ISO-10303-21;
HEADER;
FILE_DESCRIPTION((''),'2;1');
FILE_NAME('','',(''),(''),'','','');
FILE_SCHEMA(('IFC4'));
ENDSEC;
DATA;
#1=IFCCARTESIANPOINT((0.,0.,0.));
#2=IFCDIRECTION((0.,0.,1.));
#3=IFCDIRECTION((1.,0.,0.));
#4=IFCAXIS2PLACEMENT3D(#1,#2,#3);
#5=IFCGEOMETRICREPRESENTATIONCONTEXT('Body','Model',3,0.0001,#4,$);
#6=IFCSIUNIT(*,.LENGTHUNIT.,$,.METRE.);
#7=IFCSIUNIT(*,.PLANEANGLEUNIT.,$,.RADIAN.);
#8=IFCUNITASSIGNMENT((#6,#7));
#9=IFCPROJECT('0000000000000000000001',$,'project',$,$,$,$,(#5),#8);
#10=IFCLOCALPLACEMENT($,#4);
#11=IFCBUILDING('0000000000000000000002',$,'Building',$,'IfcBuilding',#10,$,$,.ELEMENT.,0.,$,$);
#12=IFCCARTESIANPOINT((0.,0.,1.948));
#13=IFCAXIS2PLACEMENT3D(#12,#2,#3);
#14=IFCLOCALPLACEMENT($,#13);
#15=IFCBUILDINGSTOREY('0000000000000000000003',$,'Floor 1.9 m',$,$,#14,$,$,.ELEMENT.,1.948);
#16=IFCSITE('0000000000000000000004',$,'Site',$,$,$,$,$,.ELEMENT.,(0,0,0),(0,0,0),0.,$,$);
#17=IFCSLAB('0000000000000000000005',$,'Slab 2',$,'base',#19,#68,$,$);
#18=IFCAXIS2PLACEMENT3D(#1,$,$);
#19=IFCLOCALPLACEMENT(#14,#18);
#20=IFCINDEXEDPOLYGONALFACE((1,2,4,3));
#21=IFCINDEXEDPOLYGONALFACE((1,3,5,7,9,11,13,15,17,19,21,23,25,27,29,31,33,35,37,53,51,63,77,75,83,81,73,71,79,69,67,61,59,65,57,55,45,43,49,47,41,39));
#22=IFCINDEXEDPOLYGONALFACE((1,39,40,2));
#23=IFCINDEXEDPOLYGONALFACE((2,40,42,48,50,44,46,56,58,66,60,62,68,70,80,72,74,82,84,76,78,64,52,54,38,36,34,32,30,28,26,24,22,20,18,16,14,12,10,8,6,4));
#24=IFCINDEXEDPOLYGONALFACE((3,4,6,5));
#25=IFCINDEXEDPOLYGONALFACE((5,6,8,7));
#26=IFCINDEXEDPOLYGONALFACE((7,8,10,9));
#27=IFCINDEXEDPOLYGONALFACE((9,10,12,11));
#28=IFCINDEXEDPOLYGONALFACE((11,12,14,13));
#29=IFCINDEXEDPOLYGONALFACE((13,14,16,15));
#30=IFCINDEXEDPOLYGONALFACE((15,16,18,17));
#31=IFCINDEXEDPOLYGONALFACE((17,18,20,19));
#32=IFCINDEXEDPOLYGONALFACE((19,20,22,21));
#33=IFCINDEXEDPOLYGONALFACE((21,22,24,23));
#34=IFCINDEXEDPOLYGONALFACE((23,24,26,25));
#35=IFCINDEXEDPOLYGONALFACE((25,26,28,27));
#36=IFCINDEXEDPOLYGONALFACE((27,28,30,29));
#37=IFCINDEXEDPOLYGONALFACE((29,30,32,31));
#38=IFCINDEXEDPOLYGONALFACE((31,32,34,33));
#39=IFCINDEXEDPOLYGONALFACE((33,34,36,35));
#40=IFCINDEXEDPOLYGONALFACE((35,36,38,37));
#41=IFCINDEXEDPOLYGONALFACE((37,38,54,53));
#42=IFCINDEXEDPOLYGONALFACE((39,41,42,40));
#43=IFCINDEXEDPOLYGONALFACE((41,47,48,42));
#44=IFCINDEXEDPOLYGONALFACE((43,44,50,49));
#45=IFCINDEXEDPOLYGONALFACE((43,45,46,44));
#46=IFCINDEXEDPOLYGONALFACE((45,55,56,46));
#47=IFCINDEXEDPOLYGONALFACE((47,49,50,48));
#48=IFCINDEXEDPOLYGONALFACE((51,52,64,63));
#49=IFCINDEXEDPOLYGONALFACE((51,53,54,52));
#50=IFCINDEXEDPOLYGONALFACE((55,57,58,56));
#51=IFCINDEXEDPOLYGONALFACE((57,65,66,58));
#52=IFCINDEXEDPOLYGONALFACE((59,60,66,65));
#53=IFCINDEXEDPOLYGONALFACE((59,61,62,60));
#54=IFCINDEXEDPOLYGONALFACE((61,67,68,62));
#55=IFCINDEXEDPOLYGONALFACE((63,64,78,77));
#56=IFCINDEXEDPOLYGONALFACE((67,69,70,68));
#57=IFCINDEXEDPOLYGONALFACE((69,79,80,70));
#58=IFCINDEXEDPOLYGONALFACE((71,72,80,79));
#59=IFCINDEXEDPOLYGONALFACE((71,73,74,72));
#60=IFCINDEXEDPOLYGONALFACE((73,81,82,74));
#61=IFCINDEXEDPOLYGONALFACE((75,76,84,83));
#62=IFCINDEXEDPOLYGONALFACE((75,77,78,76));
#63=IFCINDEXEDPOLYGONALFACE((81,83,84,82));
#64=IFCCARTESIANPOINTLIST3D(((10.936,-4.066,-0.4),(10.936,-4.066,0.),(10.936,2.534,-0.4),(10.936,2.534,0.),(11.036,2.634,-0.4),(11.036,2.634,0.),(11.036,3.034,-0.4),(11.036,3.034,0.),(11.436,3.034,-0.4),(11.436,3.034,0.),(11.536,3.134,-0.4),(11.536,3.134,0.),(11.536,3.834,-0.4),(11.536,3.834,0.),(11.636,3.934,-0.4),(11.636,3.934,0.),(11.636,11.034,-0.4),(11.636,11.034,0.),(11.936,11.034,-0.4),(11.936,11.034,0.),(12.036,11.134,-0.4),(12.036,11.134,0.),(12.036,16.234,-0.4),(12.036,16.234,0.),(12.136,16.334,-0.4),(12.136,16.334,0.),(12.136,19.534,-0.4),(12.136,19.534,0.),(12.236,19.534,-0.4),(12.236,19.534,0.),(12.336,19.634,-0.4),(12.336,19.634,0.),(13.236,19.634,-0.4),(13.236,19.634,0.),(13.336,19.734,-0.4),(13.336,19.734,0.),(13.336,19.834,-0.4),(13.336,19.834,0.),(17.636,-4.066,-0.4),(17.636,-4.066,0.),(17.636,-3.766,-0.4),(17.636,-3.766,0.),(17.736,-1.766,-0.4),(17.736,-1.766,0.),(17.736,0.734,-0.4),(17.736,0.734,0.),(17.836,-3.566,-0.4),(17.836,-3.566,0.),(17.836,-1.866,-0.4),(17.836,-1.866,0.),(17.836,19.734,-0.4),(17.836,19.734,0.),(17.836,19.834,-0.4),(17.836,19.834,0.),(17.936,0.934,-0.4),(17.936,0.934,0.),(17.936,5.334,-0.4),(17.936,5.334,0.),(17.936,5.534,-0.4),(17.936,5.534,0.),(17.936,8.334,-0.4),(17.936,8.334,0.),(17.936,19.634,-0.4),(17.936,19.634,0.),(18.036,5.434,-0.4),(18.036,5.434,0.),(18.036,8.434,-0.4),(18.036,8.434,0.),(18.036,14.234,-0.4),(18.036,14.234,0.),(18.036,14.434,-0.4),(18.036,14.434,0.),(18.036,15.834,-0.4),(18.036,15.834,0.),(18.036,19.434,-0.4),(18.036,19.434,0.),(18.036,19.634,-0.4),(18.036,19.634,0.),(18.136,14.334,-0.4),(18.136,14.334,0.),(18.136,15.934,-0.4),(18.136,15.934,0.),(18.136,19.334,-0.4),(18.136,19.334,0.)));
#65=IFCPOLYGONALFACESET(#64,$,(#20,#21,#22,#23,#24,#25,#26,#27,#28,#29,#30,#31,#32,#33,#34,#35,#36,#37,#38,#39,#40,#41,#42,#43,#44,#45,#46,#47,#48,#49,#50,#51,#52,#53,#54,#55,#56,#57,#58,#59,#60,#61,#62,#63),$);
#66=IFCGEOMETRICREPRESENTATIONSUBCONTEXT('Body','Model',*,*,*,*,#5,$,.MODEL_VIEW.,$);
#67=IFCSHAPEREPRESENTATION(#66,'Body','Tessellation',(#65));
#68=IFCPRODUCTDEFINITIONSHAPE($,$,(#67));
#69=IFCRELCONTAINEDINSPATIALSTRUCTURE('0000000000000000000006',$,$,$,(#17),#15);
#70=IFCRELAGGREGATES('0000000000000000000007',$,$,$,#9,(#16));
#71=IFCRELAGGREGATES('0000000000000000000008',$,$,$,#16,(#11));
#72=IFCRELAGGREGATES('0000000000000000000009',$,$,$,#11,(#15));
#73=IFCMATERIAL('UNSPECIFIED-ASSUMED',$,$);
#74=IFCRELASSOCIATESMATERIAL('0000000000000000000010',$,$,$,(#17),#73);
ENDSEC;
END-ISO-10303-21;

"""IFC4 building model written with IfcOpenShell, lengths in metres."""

from ifc_helpers import new_model, si_unit, frame, origin_with_axes, place, context, subcontext, project, spatial, polyline, outline, extrude, material, element, save


model = new_model("IFC4")

# Units and contexts
model_context = context("Model", 3, precision=0.0001, world=origin_with_axes(), identifier="Body")
body_context = subcontext(model_context, "Body", "Model", "MODEL_VIEW")
ifc_project = project(units=[si_unit("LENGTHUNIT", "METRE"), si_unit("PLANEANGLEUNIT", "RADIAN")], contexts=[model_context])

# Site, building, storey
site = spatial("IfcSite", under=ifc_project, Name="Site", CompositionType="ELEMENT", RefLatitude=(0, 0, 0), RefLongitude=(0, 0, 0), RefElevation=0.0)
building_placement = place(None, origin_with_axes())
building = spatial("IfcBuilding", under=site, at=building_placement, Name="Building", ObjectType="IfcBuilding", CompositionType="ELEMENT", ElevationOfRefHeight=0.0)
storey_placement = place(None, frame((0.0, 0.0, 1.948), z_axis=(0.0, 0.0, 1.0), x_axis=(1.0, 0.0, 0.0)))
storey = spatial("IfcBuildingStorey", under=building, at=storey_placement, Name="Floor 1.9 m", CompositionType="ELEMENT", Elevation=1.948)

# Slab
ifc_material = material(Name="UNSPECIFIED-ASSUMED")
slab_placement = place(None, frame((0.0, 0.0, 1.548), z_axis=(0.0, 0.0, 1.0), x_axis=(1.0, 0.0, 0.0)))
element("IfcSlab", 1, at=slab_placement, inside=storey, material=ifc_material, Name="Slab 2", ObjectType="base", context=body_context, shape_type="SweptSolid", body=[
    extrude(outline(polyline([(10.936, -4.066), (10.936, 2.534), (11.036, 2.634), (11.036, 3.034), (11.436, 3.034), (11.536, 3.134), (11.536, 3.834), (11.636, 3.934), (11.636, 11.034), (11.936, 11.034), (12.036, 11.134), (12.036, 16.234), (12.136, 16.334), (12.136, 19.534), (12.236, 19.534), (12.336, 19.634), (13.236, 19.634), (13.336, 19.734), (13.336, 19.834), (17.836, 19.834), (17.836, 19.734), (17.936, 19.634), (18.036, 19.634), (18.036, 19.434), (18.136, 19.334), (18.136, 15.934), (18.036, 15.834), (18.036, 14.434), (18.136, 14.334), (18.036, 14.234), (18.036, 8.434), (17.936, 8.334), (17.936, 5.534), (18.036, 5.434), (17.936, 5.334), (17.936, 0.934), (17.736, 0.734), (17.736, -1.766), (17.836, -1.866), (17.836, -3.566), (17.636, -3.766), (17.636, -4.066), (10.936, -4.066)])), origin_with_axes(), (0.0, 0.0, 1.0), 0.4),
])

save(model, "model.ifc")
